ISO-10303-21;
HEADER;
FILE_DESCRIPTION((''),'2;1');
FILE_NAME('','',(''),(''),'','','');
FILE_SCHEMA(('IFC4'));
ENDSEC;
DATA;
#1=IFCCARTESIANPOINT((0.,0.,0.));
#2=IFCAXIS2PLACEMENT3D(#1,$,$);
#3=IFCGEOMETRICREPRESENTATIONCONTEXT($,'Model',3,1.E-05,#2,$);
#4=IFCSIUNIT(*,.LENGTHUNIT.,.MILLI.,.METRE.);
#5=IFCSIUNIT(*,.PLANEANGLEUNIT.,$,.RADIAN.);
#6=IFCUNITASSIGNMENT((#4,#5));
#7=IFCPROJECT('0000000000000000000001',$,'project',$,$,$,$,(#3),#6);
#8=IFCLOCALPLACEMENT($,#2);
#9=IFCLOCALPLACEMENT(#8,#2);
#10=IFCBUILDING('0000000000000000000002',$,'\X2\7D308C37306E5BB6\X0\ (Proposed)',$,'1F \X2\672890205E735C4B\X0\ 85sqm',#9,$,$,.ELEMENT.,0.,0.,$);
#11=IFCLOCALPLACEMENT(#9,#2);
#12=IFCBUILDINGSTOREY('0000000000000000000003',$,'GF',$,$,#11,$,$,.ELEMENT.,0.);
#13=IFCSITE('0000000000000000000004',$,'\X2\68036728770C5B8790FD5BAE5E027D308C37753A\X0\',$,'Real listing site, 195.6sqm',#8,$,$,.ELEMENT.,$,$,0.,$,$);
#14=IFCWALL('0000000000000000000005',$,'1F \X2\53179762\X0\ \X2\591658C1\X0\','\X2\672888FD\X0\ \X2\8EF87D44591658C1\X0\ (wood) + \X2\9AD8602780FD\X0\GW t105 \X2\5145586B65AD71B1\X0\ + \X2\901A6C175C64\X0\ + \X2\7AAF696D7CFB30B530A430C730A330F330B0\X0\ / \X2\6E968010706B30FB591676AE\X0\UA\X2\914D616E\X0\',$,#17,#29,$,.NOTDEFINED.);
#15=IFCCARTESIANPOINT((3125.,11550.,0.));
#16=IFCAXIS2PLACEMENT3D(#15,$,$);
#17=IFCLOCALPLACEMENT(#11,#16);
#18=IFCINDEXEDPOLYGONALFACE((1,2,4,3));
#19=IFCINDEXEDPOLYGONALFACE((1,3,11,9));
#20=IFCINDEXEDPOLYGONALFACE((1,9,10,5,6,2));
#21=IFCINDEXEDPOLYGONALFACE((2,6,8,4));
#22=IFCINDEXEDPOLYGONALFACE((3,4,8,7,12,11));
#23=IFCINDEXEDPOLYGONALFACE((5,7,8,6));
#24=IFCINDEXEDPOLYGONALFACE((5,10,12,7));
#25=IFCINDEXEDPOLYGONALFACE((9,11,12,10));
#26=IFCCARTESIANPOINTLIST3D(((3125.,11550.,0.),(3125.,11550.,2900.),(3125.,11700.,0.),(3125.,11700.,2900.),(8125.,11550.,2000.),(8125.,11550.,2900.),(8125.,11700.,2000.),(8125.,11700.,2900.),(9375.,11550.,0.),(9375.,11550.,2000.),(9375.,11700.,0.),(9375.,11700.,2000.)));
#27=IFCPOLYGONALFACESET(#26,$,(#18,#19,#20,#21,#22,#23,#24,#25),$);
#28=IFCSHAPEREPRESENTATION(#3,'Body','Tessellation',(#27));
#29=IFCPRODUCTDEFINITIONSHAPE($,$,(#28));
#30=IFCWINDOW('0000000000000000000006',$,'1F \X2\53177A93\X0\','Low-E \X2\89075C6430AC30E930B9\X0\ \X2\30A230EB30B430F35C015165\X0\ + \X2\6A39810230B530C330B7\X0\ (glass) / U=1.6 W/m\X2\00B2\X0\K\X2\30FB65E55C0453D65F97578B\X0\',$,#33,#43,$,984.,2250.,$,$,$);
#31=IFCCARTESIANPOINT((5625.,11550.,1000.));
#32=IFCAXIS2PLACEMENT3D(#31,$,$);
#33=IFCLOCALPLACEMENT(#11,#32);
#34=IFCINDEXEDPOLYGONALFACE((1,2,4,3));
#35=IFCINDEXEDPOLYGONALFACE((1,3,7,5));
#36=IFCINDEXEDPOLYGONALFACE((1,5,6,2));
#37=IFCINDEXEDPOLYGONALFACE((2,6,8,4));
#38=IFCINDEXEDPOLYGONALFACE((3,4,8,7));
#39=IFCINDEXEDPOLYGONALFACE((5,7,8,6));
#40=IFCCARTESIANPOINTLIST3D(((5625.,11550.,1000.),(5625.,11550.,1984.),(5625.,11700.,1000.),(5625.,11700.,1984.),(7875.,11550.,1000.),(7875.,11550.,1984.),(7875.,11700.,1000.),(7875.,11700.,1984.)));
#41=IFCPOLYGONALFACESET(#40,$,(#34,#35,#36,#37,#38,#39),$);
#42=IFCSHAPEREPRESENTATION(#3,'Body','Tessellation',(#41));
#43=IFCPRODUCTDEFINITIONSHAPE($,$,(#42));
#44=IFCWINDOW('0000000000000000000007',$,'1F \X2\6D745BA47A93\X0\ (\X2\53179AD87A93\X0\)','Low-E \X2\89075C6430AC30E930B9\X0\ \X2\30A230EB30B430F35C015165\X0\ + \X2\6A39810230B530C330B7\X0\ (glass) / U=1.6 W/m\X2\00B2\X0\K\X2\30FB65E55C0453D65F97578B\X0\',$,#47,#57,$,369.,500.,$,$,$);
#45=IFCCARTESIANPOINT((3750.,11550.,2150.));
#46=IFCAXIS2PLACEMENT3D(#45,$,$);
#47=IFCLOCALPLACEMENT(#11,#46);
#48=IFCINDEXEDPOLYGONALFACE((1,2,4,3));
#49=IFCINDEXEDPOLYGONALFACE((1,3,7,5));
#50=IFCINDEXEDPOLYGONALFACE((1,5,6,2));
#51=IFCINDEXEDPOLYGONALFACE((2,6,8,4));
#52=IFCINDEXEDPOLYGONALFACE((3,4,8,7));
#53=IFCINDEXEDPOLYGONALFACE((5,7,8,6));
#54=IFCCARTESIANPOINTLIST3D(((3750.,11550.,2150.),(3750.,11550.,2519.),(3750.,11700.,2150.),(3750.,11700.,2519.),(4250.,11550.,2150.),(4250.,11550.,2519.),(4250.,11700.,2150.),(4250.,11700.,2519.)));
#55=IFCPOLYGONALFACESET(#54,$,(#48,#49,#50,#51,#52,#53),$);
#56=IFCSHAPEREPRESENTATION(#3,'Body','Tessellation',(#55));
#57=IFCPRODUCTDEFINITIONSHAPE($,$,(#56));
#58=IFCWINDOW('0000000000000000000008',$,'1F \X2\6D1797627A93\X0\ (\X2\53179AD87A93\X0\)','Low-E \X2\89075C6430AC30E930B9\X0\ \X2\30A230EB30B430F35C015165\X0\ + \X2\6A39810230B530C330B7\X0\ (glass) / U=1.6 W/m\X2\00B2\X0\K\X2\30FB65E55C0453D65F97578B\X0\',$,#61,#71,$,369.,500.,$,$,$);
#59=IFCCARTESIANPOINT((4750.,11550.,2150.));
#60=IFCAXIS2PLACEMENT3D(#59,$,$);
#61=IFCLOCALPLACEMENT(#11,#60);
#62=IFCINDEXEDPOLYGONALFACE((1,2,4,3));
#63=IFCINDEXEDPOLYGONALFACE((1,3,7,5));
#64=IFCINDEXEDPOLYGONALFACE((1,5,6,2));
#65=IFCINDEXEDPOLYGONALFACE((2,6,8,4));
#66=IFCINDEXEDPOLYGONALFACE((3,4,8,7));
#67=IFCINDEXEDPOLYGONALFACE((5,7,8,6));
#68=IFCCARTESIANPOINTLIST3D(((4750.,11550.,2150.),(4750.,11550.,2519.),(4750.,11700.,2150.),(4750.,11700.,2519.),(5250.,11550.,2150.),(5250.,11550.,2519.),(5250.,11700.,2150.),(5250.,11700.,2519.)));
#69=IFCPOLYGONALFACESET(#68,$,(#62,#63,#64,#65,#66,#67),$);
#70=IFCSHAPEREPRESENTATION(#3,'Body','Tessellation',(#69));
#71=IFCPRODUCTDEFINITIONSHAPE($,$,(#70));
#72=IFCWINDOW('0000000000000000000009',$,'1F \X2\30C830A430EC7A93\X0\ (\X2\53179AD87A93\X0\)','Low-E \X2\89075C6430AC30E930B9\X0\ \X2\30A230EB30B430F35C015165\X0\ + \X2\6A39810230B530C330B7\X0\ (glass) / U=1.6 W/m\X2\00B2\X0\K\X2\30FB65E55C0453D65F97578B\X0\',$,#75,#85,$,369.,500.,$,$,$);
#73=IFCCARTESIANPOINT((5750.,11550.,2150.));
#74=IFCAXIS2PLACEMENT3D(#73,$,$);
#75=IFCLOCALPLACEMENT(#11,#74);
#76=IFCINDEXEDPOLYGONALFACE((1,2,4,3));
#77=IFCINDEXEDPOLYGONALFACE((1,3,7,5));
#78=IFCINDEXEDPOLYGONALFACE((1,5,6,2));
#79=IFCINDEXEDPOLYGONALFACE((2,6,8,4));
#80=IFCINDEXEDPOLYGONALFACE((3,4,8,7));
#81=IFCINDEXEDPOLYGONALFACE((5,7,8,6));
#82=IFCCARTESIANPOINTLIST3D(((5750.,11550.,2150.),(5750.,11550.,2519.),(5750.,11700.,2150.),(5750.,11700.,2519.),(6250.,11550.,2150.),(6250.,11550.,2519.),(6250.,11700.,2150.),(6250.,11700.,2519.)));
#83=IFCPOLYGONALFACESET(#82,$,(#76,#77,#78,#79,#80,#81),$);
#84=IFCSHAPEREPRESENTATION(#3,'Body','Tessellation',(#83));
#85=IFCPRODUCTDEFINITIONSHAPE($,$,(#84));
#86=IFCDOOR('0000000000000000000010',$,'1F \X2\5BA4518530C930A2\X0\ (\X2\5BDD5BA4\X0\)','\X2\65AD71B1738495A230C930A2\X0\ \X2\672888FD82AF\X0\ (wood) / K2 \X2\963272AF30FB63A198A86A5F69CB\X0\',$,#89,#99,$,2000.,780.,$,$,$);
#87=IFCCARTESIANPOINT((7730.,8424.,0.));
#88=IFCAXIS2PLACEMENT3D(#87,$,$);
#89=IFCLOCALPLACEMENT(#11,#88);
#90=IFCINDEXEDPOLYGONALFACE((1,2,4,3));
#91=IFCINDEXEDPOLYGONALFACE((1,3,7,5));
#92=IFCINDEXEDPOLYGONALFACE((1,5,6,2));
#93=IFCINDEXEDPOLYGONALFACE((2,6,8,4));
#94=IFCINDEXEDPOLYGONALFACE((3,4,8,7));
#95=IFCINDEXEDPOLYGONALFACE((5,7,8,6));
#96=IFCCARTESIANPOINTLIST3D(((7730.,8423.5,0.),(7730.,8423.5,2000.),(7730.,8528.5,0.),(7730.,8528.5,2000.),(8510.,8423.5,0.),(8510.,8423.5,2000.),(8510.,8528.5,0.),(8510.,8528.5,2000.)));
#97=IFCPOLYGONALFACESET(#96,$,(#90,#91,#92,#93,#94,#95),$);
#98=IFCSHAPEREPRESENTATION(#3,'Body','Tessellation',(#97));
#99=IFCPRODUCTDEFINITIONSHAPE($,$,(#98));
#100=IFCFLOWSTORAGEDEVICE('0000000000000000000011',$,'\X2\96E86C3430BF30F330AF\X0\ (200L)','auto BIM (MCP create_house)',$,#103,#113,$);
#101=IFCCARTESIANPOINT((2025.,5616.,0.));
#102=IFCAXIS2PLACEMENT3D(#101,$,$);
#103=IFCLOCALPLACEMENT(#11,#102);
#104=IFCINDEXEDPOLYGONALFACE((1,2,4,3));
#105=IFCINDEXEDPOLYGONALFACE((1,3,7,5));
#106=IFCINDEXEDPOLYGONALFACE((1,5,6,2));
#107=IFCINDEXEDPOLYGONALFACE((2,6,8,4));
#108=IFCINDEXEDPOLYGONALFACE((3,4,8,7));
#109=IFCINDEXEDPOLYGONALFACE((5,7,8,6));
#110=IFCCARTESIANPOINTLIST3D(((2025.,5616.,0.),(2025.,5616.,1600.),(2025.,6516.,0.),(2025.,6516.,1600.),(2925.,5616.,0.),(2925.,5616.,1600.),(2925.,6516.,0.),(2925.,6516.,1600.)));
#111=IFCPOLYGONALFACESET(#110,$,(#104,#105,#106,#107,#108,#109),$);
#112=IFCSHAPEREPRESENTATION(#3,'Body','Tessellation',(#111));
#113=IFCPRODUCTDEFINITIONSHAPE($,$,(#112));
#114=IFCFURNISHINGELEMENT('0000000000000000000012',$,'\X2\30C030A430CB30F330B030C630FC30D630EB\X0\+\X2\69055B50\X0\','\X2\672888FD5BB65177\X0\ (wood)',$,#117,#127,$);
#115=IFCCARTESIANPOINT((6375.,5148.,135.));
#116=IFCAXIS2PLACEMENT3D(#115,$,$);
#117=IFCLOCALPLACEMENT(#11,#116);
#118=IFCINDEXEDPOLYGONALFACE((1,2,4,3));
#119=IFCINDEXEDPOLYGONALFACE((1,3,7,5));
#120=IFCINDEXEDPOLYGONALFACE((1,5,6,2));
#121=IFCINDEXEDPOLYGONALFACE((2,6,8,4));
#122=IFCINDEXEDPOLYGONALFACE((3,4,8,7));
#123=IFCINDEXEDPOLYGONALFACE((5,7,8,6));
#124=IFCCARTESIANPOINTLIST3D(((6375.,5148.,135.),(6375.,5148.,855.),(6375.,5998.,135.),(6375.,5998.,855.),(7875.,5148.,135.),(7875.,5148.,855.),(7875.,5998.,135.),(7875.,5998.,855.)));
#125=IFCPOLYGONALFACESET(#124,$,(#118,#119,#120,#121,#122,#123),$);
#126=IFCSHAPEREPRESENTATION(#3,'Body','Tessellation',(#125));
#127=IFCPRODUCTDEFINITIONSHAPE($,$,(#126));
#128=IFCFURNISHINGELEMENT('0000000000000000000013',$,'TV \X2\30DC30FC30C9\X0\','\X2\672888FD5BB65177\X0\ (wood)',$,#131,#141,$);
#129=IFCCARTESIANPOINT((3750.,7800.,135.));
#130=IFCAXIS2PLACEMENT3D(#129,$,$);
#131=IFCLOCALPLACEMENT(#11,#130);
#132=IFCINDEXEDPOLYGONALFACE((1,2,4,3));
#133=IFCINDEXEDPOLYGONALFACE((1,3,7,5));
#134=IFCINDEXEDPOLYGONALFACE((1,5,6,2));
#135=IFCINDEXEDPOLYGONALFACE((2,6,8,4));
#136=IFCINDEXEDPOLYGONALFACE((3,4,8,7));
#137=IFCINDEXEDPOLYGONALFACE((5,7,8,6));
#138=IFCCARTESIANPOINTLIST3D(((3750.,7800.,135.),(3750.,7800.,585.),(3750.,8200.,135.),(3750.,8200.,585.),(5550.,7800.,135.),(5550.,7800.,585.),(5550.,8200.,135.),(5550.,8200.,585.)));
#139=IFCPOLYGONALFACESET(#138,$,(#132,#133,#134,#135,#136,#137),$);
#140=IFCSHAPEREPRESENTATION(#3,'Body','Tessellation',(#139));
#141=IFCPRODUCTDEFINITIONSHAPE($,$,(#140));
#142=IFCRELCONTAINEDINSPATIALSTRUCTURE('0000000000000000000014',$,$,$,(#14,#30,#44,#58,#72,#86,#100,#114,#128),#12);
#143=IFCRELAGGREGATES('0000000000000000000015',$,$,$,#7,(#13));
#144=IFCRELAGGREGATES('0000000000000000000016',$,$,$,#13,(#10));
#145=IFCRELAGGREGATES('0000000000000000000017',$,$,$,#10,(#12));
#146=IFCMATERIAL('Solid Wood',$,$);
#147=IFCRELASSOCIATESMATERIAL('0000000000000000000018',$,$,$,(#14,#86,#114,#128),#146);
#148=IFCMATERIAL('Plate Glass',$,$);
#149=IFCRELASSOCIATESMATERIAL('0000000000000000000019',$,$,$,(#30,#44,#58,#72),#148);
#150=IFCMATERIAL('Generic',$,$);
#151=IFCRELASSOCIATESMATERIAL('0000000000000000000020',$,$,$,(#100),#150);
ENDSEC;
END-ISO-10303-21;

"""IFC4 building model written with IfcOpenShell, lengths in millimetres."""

from ifc_helpers import new_model, si_unit, frame, frame_2d, origin, place, context, project, spatial, rectangle, extrude, material, element, fill, save


model = new_model("IFC4")

# Units and contexts
model_context = context("Model", 3, precision=1e-05, world=origin())
ifc_project = project(units=[si_unit("LENGTHUNIT", "METRE", prefix="MILLI"), si_unit("PLANEANGLEUNIT", "RADIAN")], contexts=[model_context])

# Site, building, storey
site_placement = place(None, origin())
site = spatial("IfcSite", under=ifc_project, at=site_placement, Name="栃木県宇都宮市細谷町", ObjectType="Real listing site, 195.6sqm", CompositionType="ELEMENT", RefElevation=0.0)
building_placement = place(site_placement, origin())
building = spatial("IfcBuilding", under=site, at=building_placement, Name="細谷の家 (Proposed)", ObjectType="1F 木造平屋 85sqm", CompositionType="ELEMENT", ElevationOfRefHeight=0.0, ElevationOfTerrain=0.0)
storey_placement = place(building_placement, origin())
storey = spatial("IfcBuildingStorey", under=building, at=storey_placement, Name="GF", CompositionType="ELEMENT", Elevation=0.0)

# Wall, openings, windows
ifc_material_1 = material(Name="Solid Wood")
wall_1_placement = place(storey_placement, frame((3125.0, 11550.0, 0.0)))
wall_1 = element("IfcWall", 1, at=wall_1_placement, inside=storey, material=ifc_material_1, Name="1F 北面 外壁", Description="木製 軸組外壁 (wood) + 高性能GW t105 充填断熱 + 通気層 + 窯業系サイディング / 準耐火・外皮UA配慮", PredefinedType="NOTDEFINED", context=model_context, shape_type="SweptSolid", body=[
    extrude(rectangle(XDim=6250.0, YDim=150.0, at=frame_2d((3125.0, 75.0))), frame((3125.0, 11550.0, 0.0)), (0.0, 0.0, 1.0), 2900.0),
])
opening_1_placement = place(storey_placement, frame((5625.0, 11550.0, 1000.0)))
opening_1 = element("IfcOpeningElement", 2, at=opening_1_placement, cuts=wall_1, PredefinedType="NOTDEFINED", context=model_context, shape_type="SweptSolid", body=[
    extrude(rectangle(XDim=2250.0, YDim=150.0, at=frame_2d((1125.0, 75.0))), frame((5625.0, 11550.0, 1000.0)), (0.0, 0.0, 1.0), 984.0),
])
opening_2_placement = place(storey_placement, frame((3750.0, 11550.0, 2150.0)))
opening_2 = element("IfcOpeningElement", 3, at=opening_2_placement, cuts=wall_1, PredefinedType="NOTDEFINED", context=model_context, shape_type="SweptSolid", body=[
    extrude(rectangle(XDim=500.0, YDim=150.0, at=frame_2d((250.0, 75.0))), frame((3750.0, 11550.0, 2150.0)), (0.0, 0.0, 1.0), 369.0),
])
opening_3_placement = place(storey_placement, frame((4750.0, 11550.0, 2150.0)))
opening_3 = element("IfcOpeningElement", 4, at=opening_3_placement, cuts=wall_1, PredefinedType="NOTDEFINED", context=model_context, shape_type="SweptSolid", body=[
    extrude(rectangle(XDim=500.0, YDim=150.0, at=frame_2d((250.0, 75.0))), frame((4750.0, 11550.0, 2150.0)), (0.0, 0.0, 1.0), 369.0),
])
opening_4_placement = place(storey_placement, frame((5750.0, 11550.0, 2150.0)))
opening_4 = element("IfcOpeningElement", 5, at=opening_4_placement, cuts=wall_1, PredefinedType="NOTDEFINED", context=model_context, shape_type="SweptSolid", body=[
    extrude(rectangle(XDim=500.0, YDim=150.0, at=frame_2d((250.0, 75.0))), frame((5750.0, 11550.0, 2150.0)), (0.0, 0.0, 1.0), 369.0),
])
ifc_material_2 = material(Name="Plate Glass")
window_1_placement = place(storey_placement, frame((5625.0, 11550.0, 1000.0)))
window_1 = element("IfcWindow", 6, at=window_1_placement, inside=storey, material=ifc_material_2, Name="1F 北窓", Description="Low-E 複層ガラス アルゴン封入 + 樹脂サッシ (glass) / U=1.6 W/m²K・日射取得型", OverallHeight=984.0, OverallWidth=2250.0, context=model_context, shape_type="SweptSolid", body=[
    extrude(rectangle(XDim=2250.0, YDim=150.0, at=frame_2d((1125.0, 75.0))), frame((5625.0, 11550.0, 1000.0)), (0.0, 0.0, 1.0), 984.0),
])
fill(opening_1, window_1)
window_2_placement = place(storey_placement, frame((3750.0, 11550.0, 2150.0)))
window_2 = element("IfcWindow", 7, at=window_2_placement, inside=storey, material=ifc_material_2, Name="1F 浴室窓 (北高窓)", Description="Low-E 複層ガラス アルゴン封入 + 樹脂サッシ (glass) / U=1.6 W/m²K・日射取得型", OverallHeight=369.0, OverallWidth=500.0, context=model_context, shape_type="SweptSolid", body=[
    extrude(rectangle(XDim=500.0, YDim=150.0, at=frame_2d((250.0, 75.0))), frame((3750.0, 11550.0, 2150.0)), (0.0, 0.0, 1.0), 369.0),
])
fill(opening_2, window_2)
window_3_placement = place(storey_placement, frame((4750.0, 11550.0, 2150.0)))
window_3 = element("IfcWindow", 8, at=window_3_placement, inside=storey, material=ifc_material_2, Name="1F 洗面窓 (北高窓)", Description="Low-E 複層ガラス アルゴン封入 + 樹脂サッシ (glass) / U=1.6 W/m²K・日射取得型", OverallHeight=369.0, OverallWidth=500.0, context=model_context, shape_type="SweptSolid", body=[
    extrude(rectangle(XDim=500.0, YDim=150.0, at=frame_2d((250.0, 75.0))), frame((4750.0, 11550.0, 2150.0)), (0.0, 0.0, 1.0), 369.0),
])
fill(opening_3, window_3)
window_4_placement = place(storey_placement, frame((5750.0, 11550.0, 2150.0)))
window_4 = element("IfcWindow", 9, at=window_4_placement, inside=storey, material=ifc_material_2, Name="1F トイレ窓 (北高窓)", Description="Low-E 複層ガラス アルゴン封入 + 樹脂サッシ (glass) / U=1.6 W/m²K・日射取得型", OverallHeight=369.0, OverallWidth=500.0, context=model_context, shape_type="SweptSolid", body=[
    extrude(rectangle(XDim=500.0, YDim=150.0, at=frame_2d((250.0, 75.0))), frame((5750.0, 11550.0, 2150.0)), (0.0, 0.0, 1.0), 369.0),
])
fill(opening_4, window_4)

# Door
door_1_placement = place(storey_placement, frame((7730.0, 8424.0, 0.0)))
element("IfcDoor", 10, at=door_1_placement, inside=storey, material=ifc_material_1, Name="1F 室内ドア (寝室)", Description="断熱玄関ドア 木製芯 (wood) / K2 防犯・採風機構", OverallHeight=2000.0, OverallWidth=780.0, context=model_context, shape_type="SweptSolid", body=[
    extrude(rectangle(XDim=780.0, YDim=105.0, at=frame_2d((390.0, 52.0))), frame((7730.0, 8424.0, 0.0)), (0.0, 0.0, 1.0), 2000.0),
])

# Flow storage device
ifc_material_3 = material(Name="Generic")
flow_storage_device_placement = place(storey_placement, frame((2025.0, 5616.0, 0.0)))
element("IfcFlowStorageDevice", 11, at=flow_storage_device_placement, inside=storey, material=ifc_material_3, Name="雨水タンク (200L)", Description="auto BIM (MCP create_house)", context=model_context, shape_type="SweptSolid", body=[
    extrude(rectangle(XDim=900.0, YDim=900.0, at=frame_2d((450.0, 450.0))), frame((2025.0, 5616.0, 0.0)), (0.0, 0.0, 1.0), 1600.0),
])

# Furnishing elements
furnishing_1_placement = place(storey_placement, frame((6375.0, 5148.0, 135.0)))
element("IfcFurnishingElement", 12, at=furnishing_1_placement, inside=storey, material=ifc_material_1, Name="ダイニングテーブル+椅子", Description="木製家具 (wood)", context=model_context, shape_type="SweptSolid", body=[
    extrude(rectangle(XDim=1500.0, YDim=850.0, at=frame_2d((750.0, 425.0))), frame((6375.0, 5148.0, 135.0)), (0.0, 0.0, 1.0), 720.0),
])
furnishing_2_placement = place(storey_placement, frame((3750.0, 7800.0, 135.0)))
element("IfcFurnishingElement", 13, at=furnishing_2_placement, inside=storey, material=ifc_material_1, Name="TV ボード", Description="木製家具 (wood)", context=model_context, shape_type="SweptSolid", body=[
    extrude(rectangle(XDim=1800.0, YDim=400.0, at=frame_2d((900.0, 200.0))), frame((3750.0, 7800.0, 135.0)), (0.0, 0.0, 1.0), 450.0),
])

save(model, "model.ifc")
